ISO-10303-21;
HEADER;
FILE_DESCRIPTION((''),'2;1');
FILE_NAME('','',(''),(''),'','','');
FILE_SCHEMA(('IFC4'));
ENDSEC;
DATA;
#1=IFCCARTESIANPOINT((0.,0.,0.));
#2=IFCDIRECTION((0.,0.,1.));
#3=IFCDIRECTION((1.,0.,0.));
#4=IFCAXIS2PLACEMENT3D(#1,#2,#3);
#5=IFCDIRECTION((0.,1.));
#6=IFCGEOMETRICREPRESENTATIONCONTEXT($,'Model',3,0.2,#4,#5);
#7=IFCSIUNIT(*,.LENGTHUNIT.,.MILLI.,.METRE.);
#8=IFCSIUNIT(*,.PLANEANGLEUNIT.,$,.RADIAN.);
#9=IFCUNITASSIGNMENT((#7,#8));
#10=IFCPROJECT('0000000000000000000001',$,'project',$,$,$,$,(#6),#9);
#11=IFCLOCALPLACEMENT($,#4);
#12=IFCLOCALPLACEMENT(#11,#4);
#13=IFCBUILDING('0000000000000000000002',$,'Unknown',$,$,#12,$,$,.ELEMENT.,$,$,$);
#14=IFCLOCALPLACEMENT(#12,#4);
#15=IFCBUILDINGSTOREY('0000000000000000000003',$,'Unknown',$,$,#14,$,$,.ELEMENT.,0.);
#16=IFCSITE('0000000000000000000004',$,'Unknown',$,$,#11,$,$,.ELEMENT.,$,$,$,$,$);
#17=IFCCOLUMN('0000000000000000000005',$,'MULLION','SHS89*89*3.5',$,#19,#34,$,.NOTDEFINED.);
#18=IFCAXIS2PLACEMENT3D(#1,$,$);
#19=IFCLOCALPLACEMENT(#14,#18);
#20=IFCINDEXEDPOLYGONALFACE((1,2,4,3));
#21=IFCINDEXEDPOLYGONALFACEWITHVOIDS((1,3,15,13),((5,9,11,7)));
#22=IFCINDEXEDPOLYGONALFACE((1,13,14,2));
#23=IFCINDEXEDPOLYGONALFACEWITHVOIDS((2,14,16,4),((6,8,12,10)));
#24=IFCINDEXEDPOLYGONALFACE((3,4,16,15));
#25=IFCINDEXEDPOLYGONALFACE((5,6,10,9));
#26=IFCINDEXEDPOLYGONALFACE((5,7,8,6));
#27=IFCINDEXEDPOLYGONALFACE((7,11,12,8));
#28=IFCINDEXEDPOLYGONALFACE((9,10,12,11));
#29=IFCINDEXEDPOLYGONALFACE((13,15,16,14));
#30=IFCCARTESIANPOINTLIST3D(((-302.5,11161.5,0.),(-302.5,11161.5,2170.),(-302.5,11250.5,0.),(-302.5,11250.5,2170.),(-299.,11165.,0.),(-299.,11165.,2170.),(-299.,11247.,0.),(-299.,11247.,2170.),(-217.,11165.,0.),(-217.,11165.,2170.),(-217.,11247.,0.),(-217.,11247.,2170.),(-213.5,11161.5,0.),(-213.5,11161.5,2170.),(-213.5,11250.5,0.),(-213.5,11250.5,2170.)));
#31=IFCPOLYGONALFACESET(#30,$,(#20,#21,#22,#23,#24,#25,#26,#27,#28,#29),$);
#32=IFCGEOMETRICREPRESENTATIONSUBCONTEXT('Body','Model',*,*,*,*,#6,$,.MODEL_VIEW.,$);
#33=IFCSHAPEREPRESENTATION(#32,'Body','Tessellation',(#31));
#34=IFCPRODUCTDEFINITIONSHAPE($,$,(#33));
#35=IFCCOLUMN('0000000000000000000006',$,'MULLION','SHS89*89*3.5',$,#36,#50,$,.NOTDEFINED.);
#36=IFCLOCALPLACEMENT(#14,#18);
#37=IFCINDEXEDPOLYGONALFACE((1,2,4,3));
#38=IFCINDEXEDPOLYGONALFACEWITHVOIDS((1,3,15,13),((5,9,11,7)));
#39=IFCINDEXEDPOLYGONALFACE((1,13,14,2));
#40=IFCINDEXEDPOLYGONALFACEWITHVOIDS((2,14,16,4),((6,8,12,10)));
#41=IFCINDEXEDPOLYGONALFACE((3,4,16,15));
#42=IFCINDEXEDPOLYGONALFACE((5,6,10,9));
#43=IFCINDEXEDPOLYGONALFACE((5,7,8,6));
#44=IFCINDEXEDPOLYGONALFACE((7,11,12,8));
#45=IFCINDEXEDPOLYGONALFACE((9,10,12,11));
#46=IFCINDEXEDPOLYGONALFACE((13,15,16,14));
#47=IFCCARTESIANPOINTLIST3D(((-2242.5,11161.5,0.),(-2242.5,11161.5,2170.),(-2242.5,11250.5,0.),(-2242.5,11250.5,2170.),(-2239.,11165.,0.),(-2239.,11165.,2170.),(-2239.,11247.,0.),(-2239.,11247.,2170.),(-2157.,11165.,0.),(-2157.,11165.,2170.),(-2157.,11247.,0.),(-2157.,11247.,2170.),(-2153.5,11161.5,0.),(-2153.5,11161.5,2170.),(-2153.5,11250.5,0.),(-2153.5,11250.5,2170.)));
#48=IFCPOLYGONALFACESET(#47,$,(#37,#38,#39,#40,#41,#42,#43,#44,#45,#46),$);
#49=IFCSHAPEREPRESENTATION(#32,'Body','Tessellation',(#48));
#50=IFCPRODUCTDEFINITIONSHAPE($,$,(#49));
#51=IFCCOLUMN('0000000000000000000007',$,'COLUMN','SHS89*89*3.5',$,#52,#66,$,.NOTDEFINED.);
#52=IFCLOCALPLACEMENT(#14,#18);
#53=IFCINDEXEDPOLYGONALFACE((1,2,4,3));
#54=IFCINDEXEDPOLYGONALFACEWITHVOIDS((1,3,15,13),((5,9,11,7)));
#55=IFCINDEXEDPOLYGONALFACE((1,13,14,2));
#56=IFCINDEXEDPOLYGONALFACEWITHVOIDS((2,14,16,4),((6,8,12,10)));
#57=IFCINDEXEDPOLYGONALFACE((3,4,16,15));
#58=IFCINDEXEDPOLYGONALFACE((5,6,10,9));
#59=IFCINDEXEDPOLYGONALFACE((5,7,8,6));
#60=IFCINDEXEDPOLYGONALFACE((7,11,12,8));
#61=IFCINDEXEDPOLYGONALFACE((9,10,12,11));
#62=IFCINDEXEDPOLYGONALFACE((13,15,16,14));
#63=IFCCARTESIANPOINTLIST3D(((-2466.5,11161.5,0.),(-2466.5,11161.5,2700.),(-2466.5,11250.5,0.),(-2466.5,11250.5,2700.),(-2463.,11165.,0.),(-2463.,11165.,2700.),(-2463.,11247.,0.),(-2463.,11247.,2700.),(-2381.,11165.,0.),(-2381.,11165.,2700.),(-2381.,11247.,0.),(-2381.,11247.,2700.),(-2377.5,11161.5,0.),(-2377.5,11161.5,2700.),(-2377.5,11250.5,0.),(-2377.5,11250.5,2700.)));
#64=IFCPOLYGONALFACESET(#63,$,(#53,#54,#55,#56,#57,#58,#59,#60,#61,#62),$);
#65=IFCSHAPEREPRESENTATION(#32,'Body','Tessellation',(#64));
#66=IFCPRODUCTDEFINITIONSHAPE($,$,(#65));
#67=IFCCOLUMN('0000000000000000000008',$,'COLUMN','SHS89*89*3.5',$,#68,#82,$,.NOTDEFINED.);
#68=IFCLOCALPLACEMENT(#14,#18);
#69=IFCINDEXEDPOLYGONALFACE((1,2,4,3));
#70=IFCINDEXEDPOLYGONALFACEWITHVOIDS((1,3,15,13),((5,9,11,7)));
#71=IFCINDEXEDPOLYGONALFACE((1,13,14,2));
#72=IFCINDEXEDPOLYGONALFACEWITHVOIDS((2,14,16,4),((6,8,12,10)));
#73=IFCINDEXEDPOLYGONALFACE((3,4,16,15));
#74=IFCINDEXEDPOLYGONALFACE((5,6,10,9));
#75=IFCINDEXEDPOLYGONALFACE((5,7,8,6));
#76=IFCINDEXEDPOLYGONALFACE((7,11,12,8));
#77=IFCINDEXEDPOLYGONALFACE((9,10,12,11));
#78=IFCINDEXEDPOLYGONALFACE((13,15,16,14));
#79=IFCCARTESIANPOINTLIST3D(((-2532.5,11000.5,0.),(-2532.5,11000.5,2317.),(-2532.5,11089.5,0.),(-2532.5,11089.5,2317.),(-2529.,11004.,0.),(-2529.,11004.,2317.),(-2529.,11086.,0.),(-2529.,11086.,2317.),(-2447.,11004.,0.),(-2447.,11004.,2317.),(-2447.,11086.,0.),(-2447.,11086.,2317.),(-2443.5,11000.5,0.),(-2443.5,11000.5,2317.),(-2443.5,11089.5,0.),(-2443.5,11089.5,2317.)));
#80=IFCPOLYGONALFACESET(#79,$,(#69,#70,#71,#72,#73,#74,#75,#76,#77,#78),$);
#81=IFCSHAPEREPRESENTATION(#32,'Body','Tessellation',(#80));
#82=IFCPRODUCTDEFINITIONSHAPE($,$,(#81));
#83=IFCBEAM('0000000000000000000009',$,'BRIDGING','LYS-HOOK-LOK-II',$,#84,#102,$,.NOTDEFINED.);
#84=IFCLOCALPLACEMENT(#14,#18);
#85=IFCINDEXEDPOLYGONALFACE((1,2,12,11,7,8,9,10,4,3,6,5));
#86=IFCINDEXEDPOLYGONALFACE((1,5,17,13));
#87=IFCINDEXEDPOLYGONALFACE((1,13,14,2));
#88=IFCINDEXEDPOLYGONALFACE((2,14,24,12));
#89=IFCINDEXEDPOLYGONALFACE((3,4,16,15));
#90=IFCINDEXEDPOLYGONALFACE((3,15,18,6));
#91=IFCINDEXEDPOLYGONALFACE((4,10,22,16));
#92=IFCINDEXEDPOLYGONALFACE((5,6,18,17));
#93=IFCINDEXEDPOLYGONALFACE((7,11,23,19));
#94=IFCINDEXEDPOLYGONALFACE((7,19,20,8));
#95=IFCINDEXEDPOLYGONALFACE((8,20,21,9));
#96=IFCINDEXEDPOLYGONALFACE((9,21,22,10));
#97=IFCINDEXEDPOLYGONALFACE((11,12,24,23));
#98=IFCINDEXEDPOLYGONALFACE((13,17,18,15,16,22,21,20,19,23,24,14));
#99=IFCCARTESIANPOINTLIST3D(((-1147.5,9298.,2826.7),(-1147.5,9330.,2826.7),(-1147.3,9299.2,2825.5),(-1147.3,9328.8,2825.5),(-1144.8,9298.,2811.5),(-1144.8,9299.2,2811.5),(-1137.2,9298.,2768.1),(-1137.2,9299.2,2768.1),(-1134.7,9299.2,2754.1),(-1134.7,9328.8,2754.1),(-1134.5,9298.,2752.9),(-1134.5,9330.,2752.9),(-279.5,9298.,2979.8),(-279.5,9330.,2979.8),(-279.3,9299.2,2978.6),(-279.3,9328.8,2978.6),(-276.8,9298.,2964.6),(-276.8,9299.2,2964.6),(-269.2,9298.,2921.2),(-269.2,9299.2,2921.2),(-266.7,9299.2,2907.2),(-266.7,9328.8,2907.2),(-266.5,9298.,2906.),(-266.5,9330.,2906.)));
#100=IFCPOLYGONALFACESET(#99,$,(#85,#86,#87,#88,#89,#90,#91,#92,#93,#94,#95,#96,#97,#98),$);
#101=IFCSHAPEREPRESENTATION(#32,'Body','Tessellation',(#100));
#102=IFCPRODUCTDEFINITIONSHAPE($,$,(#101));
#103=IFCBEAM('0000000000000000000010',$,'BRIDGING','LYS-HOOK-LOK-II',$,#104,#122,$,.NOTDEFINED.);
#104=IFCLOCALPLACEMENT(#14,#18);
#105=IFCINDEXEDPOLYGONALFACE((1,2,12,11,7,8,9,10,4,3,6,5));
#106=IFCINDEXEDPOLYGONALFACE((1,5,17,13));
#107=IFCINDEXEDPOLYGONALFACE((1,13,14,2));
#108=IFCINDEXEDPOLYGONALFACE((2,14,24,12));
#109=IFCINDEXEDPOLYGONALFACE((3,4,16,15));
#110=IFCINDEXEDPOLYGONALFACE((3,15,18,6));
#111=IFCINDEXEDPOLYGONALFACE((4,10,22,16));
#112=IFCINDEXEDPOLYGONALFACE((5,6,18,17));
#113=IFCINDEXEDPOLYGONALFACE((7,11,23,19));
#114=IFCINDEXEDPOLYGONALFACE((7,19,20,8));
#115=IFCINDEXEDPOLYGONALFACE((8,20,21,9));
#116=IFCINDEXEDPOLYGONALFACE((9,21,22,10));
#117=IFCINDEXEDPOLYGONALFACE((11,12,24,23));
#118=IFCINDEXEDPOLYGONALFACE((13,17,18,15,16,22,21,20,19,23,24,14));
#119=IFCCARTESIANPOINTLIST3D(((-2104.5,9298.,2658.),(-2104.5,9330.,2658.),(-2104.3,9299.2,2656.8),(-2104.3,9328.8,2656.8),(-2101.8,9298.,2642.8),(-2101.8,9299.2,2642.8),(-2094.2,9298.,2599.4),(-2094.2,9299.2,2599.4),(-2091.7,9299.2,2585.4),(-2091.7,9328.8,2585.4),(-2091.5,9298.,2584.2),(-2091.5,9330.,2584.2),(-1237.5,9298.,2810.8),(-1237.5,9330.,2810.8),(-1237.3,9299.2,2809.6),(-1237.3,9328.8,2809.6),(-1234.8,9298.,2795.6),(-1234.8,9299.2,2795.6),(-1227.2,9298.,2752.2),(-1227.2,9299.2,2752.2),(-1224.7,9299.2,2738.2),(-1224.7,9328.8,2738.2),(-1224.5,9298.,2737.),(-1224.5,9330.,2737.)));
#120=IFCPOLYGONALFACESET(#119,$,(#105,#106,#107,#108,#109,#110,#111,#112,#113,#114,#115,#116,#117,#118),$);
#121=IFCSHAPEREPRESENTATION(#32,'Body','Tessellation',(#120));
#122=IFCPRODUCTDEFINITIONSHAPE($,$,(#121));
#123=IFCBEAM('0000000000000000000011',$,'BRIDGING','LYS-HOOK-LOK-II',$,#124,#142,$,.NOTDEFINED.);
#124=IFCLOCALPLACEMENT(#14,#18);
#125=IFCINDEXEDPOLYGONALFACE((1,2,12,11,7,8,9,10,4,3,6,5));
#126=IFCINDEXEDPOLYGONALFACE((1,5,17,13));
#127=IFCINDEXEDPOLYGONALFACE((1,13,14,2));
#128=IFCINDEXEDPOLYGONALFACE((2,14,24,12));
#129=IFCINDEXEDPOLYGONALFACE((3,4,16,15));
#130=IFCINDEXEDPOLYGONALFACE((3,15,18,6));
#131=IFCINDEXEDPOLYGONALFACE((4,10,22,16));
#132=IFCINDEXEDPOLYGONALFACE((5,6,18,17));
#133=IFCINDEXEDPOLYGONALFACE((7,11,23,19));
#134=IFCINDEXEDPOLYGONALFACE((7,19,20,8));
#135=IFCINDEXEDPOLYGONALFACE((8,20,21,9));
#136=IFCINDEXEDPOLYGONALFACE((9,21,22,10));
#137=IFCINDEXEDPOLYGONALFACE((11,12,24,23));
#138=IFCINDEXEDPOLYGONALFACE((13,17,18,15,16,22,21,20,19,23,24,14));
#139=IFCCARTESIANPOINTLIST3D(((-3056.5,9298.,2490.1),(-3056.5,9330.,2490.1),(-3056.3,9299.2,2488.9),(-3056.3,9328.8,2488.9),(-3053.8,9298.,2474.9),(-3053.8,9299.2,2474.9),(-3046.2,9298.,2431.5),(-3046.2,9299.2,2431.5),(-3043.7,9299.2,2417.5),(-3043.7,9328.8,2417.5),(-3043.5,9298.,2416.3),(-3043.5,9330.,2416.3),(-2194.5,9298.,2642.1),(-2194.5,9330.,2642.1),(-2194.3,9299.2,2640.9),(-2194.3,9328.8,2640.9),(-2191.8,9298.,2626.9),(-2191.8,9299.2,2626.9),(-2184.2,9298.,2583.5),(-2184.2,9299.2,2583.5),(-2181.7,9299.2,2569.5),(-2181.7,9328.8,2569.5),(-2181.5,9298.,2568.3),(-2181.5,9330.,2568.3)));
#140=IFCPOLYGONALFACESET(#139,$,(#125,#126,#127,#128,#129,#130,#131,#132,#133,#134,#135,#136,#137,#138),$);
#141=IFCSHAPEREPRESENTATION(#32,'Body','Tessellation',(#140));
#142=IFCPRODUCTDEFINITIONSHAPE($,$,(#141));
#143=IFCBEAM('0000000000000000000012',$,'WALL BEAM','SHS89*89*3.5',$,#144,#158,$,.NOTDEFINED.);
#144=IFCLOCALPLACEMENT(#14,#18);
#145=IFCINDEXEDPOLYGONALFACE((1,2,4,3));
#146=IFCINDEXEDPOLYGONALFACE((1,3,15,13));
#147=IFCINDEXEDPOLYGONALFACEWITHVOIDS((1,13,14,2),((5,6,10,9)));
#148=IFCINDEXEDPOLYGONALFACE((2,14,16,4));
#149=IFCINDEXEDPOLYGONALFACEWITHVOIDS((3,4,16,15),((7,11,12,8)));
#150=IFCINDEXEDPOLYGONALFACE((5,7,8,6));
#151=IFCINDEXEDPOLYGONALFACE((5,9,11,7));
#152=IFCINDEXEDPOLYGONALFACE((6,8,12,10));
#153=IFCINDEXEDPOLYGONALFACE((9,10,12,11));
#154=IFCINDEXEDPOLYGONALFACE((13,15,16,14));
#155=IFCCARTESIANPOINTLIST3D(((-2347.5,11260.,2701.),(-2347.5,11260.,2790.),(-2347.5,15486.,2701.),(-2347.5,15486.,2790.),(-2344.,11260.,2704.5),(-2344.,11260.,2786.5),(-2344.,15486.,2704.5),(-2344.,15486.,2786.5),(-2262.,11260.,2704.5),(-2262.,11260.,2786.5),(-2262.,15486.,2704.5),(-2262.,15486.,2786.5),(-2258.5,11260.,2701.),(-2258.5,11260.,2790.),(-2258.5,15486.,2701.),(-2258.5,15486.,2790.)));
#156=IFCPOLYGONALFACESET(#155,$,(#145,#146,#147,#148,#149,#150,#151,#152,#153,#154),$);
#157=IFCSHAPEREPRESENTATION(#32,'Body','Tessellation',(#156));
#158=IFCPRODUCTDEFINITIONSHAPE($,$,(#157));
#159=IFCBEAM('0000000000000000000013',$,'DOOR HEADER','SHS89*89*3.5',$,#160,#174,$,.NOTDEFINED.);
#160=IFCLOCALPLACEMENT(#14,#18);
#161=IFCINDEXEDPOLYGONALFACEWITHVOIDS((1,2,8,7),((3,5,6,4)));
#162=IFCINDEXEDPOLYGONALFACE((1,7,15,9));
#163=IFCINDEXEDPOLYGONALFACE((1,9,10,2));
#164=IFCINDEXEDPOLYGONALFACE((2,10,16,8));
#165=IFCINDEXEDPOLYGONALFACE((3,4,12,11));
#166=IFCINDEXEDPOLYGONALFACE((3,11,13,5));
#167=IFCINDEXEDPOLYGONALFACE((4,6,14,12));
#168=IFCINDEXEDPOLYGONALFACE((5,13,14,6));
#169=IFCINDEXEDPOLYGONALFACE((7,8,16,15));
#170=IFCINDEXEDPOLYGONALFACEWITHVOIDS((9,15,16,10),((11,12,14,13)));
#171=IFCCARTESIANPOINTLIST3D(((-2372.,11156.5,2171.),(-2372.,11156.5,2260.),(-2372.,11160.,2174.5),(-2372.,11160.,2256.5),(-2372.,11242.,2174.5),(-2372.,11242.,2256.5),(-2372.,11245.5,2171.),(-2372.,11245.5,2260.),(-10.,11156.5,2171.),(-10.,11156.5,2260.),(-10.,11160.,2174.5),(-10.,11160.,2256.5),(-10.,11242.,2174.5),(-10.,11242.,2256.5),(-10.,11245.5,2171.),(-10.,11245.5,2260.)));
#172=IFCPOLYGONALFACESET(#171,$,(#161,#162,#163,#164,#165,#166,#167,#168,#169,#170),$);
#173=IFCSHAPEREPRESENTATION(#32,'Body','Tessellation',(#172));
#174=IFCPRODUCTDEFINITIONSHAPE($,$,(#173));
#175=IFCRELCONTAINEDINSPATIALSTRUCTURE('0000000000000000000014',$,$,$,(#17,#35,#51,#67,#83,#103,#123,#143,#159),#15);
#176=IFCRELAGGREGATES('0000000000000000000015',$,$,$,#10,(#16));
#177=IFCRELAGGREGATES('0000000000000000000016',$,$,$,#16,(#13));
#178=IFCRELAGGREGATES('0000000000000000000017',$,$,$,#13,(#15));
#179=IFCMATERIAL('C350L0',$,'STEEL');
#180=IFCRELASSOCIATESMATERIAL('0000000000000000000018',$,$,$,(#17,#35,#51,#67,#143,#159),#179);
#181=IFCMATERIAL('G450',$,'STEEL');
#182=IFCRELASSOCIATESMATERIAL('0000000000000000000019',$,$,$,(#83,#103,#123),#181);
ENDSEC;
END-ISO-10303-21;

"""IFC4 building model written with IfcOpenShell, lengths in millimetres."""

from ifc_helpers import new_model, si_unit, direction, frame, origin_with_axes, place, context, subcontext, project, spatial, line, indexed_curve, outline, extrude, material, element, save


model = new_model("IFC4")

# Units and contexts
model_context = context("Model", 3, precision=0.2, world=origin_with_axes(), true_north=direction((0.0, 1.0)))
body_context = subcontext(model_context, "Body", "Model", "MODEL_VIEW")
ifc_project = project(units=[si_unit("LENGTHUNIT", "METRE", prefix="MILLI"), si_unit("PLANEANGLEUNIT", "RADIAN")], contexts=[model_context])

# Site, building, storey
site_placement = place(None, origin_with_axes())
site = spatial("IfcSite", under=ifc_project, at=site_placement, Name="Unknown", CompositionType="ELEMENT")
building_placement = place(site_placement, origin_with_axes())
building = spatial("IfcBuilding", under=site, at=building_placement, Name="Unknown", CompositionType="ELEMENT")
storey_placement = place(building_placement, origin_with_axes())
storey = spatial("IfcBuildingStorey", under=building, at=storey_placement, Name="Unknown", CompositionType="ELEMENT", Elevation=0.0)

# Columns
ifc_material_1 = material(Name="C350L0", Category="STEEL")
for number, where, z_axis, x_axis, name in (
    (1, (-258.0, 11206.0, 0.0), (-1.0, 0.0, 0.0), (0.0, 0.0, 1.0), "MULLION"),
    (2, (-2198.0, 11206.0, 0.0), (-1.0, 0.0, 0.0), (0.0, 0.0, 1.0), "MULLION"),
):
    element("IfcColumn", number, at=place(storey_placement, frame(where, z_axis=z_axis, x_axis=x_axis)), inside=storey, material=ifc_material_1, Name=name, Description="SHS89*89*3.5", PredefinedType="NOTDEFINED", context=body_context, shape_type="SolidModel", body=[
        extrude(outline(indexed_curve([(-44.5, -44.5), (44.5, -44.5), (44.5, 44.5), (-44.5, 44.5)], segments=[line(1, 2, 3, 4, 1)]), holes=[indexed_curve([(-41.0, -41.0), (-41.0, 41.0), (41.0, 41.0), (41.0, -41.0)], segments=[line(1, 2, 3, 4, 1)])]), frame((0.0, 0.0, 0.0), z_axis=(-1.0, 0.0, 0.0), x_axis=(0.0, 0.0, 1.0)), (0.0, 0.0, -1.0), 2170.0),
    ])
column_1_placement = place(storey_placement, frame((-2422.0, 11206.0, 0.0), z_axis=(-1.0, 0.0, 0.0), x_axis=(0.0, 0.0, 1.0)))
element("IfcColumn", 3, at=column_1_placement, inside=storey, material=ifc_material_1, Name="COLUMN", Description="SHS89*89*3.5", PredefinedType="NOTDEFINED", context=body_context, shape_type="SolidModel", body=[
    extrude(outline(indexed_curve([(-44.5, -44.5), (44.5, -44.5), (44.5, 44.5), (-44.5, 44.5)], segments=[line(1, 2, 3, 4, 1)]), holes=[indexed_curve([(-41.0, -41.0), (-41.0, 41.0), (41.0, 41.0), (41.0, -41.0)], segments=[line(1, 2, 3, 4, 1)])]), frame((0.0, 0.0, 0.0), z_axis=(-1.0, 0.0, 0.0), x_axis=(0.0, 0.0, 1.0)), (0.0, 0.0, -1.0), 2700.0),
])
column_2_placement = place(storey_placement, frame((-2488.0, 11045.0, 0.0), z_axis=(-1.0, 0.0, 0.0), x_axis=(0.0, 0.0, 1.0)))
element("IfcColumn", 4, at=column_2_placement, inside=storey, material=ifc_material_1, Name="COLUMN", Description="SHS89*89*3.5", PredefinedType="NOTDEFINED", context=body_context, shape_type="SolidModel", body=[
    extrude(outline(indexed_curve([(-44.5, -44.5), (44.5, -44.5), (44.5, 44.5), (-44.5, 44.5)], segments=[line(1, 2, 3, 4, 1)]), holes=[indexed_curve([(-41.0, -41.0), (-41.0, 41.0), (41.0, 41.0), (41.0, -41.0)], segments=[line(1, 2, 3, 4, 1)])]), frame((0.0, 0.0, 0.0), z_axis=(-1.0, 0.0, 0.0), x_axis=(0.0, 0.0, 1.0)), (0.0, 0.0, -1.0), 2317.0),
])

# Beams
ifc_material_2 = material(Name="G450", Category="STEEL")
beam_1_placement = place(storey_placement, frame((-1141.0, 9314.0, 2789.8), z_axis=(0.0, -1.0, 0.0), x_axis=(0.984798, 0.0, 0.173701)))
element("IfcBeam", 5, at=beam_1_placement, inside=storey, material=ifc_material_2, Name="BRIDGING", Description="LYS-HOOK-LOK-II", PredefinedType="NOTDEFINED", context=body_context, shape_type="SolidModel", body=[
    extrude(outline(indexed_curve([(16.0, -37.5), (16.0, -22.0), (14.8, -22.0), (14.8, -36.3), (-14.8, -36.3), (-14.8, 36.3), (14.8, 36.3), (14.8, 22.0), (16.0, 22.0), (16.0, 37.5), (-16.0, 37.5), (-16.0, -37.5)], segments=[line(1, 2, 3, 4, 5, 6, 7, 8, 9, 10, 11, 12, 1)])), frame((0.0, 0.0, 0.0), z_axis=(-1.0, 0.0, 0.0), x_axis=(0.0, 0.0, 1.0)), (0.0, 0.0, -1.0), 881.4),
])
beam_2_placement = place(storey_placement, frame((-2098.0, 9314.0, 2621.1), z_axis=(0.0, -1.0, 0.0), x_axis=(0.984822, 0.0, 0.173565)))
element("IfcBeam", 6, at=beam_2_placement, inside=storey, material=ifc_material_2, Name="BRIDGING", Description="LYS-HOOK-LOK-II", PredefinedType="NOTDEFINED", context=body_context, shape_type="SolidModel", body=[
    extrude(outline(indexed_curve([(16.0, -37.5), (16.0, -22.0), (14.8, -22.0), (14.8, -36.3), (-14.8, -36.3), (-14.8, 36.3), (14.8, 36.3), (14.8, 22.0), (16.0, 22.0), (16.0, 37.5), (-16.0, 37.5), (-16.0, -37.5)], segments=[line(1, 2, 3, 4, 5, 6, 7, 8, 9, 10, 11, 12, 1)])), frame((0.0, 0.0, 0.0), z_axis=(-1.0, 0.0, 0.0), x_axis=(0.0, 0.0, 1.0)), (0.0, 0.0, -1.0), 880.4),
])
beam_3_placement = place(storey_placement, frame((-3050.0, 9314.0, 2453.2), z_axis=(0.0, -1.0, 0.0), x_axis=(0.984807, 0.0, 0.173655)))
element("IfcBeam", 7, at=beam_3_placement, inside=storey, material=ifc_material_2, Name="BRIDGING", Description="LYS-HOOK-LOK-II", PredefinedType="NOTDEFINED", context=body_context, shape_type="SolidModel", body=[
    extrude(outline(indexed_curve([(16.0, -37.5), (16.0, -22.0), (14.8, -22.0), (14.8, -36.3), (-14.8, -36.3), (-14.8, 36.3), (14.8, 36.3), (14.8, 22.0), (16.0, 22.0), (16.0, 37.5), (-16.0, 37.5), (-16.0, -37.5)], segments=[line(1, 2, 3, 4, 5, 6, 7, 8, 9, 10, 11, 12, 1)])), frame((0.0, 0.0, 0.0), z_axis=(-1.0, 0.0, 0.0), x_axis=(0.0, 0.0, 1.0)), (0.0, 0.0, -1.0), 875.3),
])
beam_4_placement = place(storey_placement, frame((-2303.0, 11260.0, 2745.5), z_axis=(0.0, 0.0, 1.0), x_axis=(0.0, 1.0, 0.0)))
element("IfcBeam", 8, at=beam_4_placement, inside=storey, material=ifc_material_1, Name="WALL BEAM", Description="SHS89*89*3.5", PredefinedType="NOTDEFINED", context=body_context, shape_type="SolidModel", body=[
    extrude(outline(indexed_curve([(-44.5, -44.5), (44.5, -44.5), (44.5, 44.5), (-44.5, 44.5)], segments=[line(1, 2, 3, 4, 1)]), holes=[indexed_curve([(-41.0, -41.0), (-41.0, 41.0), (41.0, 41.0), (41.0, -41.0)], segments=[line(1, 2, 3, 4, 1)])]), frame((0.0, 0.0, 0.0), z_axis=(-1.0, 0.0, 0.0), x_axis=(0.0, 0.0, 1.0)), (0.0, 0.0, -1.0), 4226.0),
])
beam_5_placement = place(storey_placement, frame((-2372.0, 11201.0, 2215.5), z_axis=(0.0, 0.0, 1.0), x_axis=(1.0, 0.0, 0.0)))
element("IfcBeam", 9, at=beam_5_placement, inside=storey, material=ifc_material_1, Name="DOOR HEADER", Description="SHS89*89*3.5", PredefinedType="NOTDEFINED", context=body_context, shape_type="SolidModel", body=[
    extrude(outline(indexed_curve([(-44.5, -44.5), (44.5, -44.5), (44.5, 44.5), (-44.5, 44.5)], segments=[line(1, 2, 3, 4, 1)]), holes=[indexed_curve([(-41.0, -41.0), (-41.0, 41.0), (41.0, 41.0), (41.0, -41.0)], segments=[line(1, 2, 3, 4, 1)])]), frame((0.0, 0.0, 0.0), z_axis=(-1.0, 0.0, 0.0), x_axis=(0.0, 0.0, 1.0)), (0.0, 0.0, -1.0), 2362.0),
])

save(model, "model.ifc")
